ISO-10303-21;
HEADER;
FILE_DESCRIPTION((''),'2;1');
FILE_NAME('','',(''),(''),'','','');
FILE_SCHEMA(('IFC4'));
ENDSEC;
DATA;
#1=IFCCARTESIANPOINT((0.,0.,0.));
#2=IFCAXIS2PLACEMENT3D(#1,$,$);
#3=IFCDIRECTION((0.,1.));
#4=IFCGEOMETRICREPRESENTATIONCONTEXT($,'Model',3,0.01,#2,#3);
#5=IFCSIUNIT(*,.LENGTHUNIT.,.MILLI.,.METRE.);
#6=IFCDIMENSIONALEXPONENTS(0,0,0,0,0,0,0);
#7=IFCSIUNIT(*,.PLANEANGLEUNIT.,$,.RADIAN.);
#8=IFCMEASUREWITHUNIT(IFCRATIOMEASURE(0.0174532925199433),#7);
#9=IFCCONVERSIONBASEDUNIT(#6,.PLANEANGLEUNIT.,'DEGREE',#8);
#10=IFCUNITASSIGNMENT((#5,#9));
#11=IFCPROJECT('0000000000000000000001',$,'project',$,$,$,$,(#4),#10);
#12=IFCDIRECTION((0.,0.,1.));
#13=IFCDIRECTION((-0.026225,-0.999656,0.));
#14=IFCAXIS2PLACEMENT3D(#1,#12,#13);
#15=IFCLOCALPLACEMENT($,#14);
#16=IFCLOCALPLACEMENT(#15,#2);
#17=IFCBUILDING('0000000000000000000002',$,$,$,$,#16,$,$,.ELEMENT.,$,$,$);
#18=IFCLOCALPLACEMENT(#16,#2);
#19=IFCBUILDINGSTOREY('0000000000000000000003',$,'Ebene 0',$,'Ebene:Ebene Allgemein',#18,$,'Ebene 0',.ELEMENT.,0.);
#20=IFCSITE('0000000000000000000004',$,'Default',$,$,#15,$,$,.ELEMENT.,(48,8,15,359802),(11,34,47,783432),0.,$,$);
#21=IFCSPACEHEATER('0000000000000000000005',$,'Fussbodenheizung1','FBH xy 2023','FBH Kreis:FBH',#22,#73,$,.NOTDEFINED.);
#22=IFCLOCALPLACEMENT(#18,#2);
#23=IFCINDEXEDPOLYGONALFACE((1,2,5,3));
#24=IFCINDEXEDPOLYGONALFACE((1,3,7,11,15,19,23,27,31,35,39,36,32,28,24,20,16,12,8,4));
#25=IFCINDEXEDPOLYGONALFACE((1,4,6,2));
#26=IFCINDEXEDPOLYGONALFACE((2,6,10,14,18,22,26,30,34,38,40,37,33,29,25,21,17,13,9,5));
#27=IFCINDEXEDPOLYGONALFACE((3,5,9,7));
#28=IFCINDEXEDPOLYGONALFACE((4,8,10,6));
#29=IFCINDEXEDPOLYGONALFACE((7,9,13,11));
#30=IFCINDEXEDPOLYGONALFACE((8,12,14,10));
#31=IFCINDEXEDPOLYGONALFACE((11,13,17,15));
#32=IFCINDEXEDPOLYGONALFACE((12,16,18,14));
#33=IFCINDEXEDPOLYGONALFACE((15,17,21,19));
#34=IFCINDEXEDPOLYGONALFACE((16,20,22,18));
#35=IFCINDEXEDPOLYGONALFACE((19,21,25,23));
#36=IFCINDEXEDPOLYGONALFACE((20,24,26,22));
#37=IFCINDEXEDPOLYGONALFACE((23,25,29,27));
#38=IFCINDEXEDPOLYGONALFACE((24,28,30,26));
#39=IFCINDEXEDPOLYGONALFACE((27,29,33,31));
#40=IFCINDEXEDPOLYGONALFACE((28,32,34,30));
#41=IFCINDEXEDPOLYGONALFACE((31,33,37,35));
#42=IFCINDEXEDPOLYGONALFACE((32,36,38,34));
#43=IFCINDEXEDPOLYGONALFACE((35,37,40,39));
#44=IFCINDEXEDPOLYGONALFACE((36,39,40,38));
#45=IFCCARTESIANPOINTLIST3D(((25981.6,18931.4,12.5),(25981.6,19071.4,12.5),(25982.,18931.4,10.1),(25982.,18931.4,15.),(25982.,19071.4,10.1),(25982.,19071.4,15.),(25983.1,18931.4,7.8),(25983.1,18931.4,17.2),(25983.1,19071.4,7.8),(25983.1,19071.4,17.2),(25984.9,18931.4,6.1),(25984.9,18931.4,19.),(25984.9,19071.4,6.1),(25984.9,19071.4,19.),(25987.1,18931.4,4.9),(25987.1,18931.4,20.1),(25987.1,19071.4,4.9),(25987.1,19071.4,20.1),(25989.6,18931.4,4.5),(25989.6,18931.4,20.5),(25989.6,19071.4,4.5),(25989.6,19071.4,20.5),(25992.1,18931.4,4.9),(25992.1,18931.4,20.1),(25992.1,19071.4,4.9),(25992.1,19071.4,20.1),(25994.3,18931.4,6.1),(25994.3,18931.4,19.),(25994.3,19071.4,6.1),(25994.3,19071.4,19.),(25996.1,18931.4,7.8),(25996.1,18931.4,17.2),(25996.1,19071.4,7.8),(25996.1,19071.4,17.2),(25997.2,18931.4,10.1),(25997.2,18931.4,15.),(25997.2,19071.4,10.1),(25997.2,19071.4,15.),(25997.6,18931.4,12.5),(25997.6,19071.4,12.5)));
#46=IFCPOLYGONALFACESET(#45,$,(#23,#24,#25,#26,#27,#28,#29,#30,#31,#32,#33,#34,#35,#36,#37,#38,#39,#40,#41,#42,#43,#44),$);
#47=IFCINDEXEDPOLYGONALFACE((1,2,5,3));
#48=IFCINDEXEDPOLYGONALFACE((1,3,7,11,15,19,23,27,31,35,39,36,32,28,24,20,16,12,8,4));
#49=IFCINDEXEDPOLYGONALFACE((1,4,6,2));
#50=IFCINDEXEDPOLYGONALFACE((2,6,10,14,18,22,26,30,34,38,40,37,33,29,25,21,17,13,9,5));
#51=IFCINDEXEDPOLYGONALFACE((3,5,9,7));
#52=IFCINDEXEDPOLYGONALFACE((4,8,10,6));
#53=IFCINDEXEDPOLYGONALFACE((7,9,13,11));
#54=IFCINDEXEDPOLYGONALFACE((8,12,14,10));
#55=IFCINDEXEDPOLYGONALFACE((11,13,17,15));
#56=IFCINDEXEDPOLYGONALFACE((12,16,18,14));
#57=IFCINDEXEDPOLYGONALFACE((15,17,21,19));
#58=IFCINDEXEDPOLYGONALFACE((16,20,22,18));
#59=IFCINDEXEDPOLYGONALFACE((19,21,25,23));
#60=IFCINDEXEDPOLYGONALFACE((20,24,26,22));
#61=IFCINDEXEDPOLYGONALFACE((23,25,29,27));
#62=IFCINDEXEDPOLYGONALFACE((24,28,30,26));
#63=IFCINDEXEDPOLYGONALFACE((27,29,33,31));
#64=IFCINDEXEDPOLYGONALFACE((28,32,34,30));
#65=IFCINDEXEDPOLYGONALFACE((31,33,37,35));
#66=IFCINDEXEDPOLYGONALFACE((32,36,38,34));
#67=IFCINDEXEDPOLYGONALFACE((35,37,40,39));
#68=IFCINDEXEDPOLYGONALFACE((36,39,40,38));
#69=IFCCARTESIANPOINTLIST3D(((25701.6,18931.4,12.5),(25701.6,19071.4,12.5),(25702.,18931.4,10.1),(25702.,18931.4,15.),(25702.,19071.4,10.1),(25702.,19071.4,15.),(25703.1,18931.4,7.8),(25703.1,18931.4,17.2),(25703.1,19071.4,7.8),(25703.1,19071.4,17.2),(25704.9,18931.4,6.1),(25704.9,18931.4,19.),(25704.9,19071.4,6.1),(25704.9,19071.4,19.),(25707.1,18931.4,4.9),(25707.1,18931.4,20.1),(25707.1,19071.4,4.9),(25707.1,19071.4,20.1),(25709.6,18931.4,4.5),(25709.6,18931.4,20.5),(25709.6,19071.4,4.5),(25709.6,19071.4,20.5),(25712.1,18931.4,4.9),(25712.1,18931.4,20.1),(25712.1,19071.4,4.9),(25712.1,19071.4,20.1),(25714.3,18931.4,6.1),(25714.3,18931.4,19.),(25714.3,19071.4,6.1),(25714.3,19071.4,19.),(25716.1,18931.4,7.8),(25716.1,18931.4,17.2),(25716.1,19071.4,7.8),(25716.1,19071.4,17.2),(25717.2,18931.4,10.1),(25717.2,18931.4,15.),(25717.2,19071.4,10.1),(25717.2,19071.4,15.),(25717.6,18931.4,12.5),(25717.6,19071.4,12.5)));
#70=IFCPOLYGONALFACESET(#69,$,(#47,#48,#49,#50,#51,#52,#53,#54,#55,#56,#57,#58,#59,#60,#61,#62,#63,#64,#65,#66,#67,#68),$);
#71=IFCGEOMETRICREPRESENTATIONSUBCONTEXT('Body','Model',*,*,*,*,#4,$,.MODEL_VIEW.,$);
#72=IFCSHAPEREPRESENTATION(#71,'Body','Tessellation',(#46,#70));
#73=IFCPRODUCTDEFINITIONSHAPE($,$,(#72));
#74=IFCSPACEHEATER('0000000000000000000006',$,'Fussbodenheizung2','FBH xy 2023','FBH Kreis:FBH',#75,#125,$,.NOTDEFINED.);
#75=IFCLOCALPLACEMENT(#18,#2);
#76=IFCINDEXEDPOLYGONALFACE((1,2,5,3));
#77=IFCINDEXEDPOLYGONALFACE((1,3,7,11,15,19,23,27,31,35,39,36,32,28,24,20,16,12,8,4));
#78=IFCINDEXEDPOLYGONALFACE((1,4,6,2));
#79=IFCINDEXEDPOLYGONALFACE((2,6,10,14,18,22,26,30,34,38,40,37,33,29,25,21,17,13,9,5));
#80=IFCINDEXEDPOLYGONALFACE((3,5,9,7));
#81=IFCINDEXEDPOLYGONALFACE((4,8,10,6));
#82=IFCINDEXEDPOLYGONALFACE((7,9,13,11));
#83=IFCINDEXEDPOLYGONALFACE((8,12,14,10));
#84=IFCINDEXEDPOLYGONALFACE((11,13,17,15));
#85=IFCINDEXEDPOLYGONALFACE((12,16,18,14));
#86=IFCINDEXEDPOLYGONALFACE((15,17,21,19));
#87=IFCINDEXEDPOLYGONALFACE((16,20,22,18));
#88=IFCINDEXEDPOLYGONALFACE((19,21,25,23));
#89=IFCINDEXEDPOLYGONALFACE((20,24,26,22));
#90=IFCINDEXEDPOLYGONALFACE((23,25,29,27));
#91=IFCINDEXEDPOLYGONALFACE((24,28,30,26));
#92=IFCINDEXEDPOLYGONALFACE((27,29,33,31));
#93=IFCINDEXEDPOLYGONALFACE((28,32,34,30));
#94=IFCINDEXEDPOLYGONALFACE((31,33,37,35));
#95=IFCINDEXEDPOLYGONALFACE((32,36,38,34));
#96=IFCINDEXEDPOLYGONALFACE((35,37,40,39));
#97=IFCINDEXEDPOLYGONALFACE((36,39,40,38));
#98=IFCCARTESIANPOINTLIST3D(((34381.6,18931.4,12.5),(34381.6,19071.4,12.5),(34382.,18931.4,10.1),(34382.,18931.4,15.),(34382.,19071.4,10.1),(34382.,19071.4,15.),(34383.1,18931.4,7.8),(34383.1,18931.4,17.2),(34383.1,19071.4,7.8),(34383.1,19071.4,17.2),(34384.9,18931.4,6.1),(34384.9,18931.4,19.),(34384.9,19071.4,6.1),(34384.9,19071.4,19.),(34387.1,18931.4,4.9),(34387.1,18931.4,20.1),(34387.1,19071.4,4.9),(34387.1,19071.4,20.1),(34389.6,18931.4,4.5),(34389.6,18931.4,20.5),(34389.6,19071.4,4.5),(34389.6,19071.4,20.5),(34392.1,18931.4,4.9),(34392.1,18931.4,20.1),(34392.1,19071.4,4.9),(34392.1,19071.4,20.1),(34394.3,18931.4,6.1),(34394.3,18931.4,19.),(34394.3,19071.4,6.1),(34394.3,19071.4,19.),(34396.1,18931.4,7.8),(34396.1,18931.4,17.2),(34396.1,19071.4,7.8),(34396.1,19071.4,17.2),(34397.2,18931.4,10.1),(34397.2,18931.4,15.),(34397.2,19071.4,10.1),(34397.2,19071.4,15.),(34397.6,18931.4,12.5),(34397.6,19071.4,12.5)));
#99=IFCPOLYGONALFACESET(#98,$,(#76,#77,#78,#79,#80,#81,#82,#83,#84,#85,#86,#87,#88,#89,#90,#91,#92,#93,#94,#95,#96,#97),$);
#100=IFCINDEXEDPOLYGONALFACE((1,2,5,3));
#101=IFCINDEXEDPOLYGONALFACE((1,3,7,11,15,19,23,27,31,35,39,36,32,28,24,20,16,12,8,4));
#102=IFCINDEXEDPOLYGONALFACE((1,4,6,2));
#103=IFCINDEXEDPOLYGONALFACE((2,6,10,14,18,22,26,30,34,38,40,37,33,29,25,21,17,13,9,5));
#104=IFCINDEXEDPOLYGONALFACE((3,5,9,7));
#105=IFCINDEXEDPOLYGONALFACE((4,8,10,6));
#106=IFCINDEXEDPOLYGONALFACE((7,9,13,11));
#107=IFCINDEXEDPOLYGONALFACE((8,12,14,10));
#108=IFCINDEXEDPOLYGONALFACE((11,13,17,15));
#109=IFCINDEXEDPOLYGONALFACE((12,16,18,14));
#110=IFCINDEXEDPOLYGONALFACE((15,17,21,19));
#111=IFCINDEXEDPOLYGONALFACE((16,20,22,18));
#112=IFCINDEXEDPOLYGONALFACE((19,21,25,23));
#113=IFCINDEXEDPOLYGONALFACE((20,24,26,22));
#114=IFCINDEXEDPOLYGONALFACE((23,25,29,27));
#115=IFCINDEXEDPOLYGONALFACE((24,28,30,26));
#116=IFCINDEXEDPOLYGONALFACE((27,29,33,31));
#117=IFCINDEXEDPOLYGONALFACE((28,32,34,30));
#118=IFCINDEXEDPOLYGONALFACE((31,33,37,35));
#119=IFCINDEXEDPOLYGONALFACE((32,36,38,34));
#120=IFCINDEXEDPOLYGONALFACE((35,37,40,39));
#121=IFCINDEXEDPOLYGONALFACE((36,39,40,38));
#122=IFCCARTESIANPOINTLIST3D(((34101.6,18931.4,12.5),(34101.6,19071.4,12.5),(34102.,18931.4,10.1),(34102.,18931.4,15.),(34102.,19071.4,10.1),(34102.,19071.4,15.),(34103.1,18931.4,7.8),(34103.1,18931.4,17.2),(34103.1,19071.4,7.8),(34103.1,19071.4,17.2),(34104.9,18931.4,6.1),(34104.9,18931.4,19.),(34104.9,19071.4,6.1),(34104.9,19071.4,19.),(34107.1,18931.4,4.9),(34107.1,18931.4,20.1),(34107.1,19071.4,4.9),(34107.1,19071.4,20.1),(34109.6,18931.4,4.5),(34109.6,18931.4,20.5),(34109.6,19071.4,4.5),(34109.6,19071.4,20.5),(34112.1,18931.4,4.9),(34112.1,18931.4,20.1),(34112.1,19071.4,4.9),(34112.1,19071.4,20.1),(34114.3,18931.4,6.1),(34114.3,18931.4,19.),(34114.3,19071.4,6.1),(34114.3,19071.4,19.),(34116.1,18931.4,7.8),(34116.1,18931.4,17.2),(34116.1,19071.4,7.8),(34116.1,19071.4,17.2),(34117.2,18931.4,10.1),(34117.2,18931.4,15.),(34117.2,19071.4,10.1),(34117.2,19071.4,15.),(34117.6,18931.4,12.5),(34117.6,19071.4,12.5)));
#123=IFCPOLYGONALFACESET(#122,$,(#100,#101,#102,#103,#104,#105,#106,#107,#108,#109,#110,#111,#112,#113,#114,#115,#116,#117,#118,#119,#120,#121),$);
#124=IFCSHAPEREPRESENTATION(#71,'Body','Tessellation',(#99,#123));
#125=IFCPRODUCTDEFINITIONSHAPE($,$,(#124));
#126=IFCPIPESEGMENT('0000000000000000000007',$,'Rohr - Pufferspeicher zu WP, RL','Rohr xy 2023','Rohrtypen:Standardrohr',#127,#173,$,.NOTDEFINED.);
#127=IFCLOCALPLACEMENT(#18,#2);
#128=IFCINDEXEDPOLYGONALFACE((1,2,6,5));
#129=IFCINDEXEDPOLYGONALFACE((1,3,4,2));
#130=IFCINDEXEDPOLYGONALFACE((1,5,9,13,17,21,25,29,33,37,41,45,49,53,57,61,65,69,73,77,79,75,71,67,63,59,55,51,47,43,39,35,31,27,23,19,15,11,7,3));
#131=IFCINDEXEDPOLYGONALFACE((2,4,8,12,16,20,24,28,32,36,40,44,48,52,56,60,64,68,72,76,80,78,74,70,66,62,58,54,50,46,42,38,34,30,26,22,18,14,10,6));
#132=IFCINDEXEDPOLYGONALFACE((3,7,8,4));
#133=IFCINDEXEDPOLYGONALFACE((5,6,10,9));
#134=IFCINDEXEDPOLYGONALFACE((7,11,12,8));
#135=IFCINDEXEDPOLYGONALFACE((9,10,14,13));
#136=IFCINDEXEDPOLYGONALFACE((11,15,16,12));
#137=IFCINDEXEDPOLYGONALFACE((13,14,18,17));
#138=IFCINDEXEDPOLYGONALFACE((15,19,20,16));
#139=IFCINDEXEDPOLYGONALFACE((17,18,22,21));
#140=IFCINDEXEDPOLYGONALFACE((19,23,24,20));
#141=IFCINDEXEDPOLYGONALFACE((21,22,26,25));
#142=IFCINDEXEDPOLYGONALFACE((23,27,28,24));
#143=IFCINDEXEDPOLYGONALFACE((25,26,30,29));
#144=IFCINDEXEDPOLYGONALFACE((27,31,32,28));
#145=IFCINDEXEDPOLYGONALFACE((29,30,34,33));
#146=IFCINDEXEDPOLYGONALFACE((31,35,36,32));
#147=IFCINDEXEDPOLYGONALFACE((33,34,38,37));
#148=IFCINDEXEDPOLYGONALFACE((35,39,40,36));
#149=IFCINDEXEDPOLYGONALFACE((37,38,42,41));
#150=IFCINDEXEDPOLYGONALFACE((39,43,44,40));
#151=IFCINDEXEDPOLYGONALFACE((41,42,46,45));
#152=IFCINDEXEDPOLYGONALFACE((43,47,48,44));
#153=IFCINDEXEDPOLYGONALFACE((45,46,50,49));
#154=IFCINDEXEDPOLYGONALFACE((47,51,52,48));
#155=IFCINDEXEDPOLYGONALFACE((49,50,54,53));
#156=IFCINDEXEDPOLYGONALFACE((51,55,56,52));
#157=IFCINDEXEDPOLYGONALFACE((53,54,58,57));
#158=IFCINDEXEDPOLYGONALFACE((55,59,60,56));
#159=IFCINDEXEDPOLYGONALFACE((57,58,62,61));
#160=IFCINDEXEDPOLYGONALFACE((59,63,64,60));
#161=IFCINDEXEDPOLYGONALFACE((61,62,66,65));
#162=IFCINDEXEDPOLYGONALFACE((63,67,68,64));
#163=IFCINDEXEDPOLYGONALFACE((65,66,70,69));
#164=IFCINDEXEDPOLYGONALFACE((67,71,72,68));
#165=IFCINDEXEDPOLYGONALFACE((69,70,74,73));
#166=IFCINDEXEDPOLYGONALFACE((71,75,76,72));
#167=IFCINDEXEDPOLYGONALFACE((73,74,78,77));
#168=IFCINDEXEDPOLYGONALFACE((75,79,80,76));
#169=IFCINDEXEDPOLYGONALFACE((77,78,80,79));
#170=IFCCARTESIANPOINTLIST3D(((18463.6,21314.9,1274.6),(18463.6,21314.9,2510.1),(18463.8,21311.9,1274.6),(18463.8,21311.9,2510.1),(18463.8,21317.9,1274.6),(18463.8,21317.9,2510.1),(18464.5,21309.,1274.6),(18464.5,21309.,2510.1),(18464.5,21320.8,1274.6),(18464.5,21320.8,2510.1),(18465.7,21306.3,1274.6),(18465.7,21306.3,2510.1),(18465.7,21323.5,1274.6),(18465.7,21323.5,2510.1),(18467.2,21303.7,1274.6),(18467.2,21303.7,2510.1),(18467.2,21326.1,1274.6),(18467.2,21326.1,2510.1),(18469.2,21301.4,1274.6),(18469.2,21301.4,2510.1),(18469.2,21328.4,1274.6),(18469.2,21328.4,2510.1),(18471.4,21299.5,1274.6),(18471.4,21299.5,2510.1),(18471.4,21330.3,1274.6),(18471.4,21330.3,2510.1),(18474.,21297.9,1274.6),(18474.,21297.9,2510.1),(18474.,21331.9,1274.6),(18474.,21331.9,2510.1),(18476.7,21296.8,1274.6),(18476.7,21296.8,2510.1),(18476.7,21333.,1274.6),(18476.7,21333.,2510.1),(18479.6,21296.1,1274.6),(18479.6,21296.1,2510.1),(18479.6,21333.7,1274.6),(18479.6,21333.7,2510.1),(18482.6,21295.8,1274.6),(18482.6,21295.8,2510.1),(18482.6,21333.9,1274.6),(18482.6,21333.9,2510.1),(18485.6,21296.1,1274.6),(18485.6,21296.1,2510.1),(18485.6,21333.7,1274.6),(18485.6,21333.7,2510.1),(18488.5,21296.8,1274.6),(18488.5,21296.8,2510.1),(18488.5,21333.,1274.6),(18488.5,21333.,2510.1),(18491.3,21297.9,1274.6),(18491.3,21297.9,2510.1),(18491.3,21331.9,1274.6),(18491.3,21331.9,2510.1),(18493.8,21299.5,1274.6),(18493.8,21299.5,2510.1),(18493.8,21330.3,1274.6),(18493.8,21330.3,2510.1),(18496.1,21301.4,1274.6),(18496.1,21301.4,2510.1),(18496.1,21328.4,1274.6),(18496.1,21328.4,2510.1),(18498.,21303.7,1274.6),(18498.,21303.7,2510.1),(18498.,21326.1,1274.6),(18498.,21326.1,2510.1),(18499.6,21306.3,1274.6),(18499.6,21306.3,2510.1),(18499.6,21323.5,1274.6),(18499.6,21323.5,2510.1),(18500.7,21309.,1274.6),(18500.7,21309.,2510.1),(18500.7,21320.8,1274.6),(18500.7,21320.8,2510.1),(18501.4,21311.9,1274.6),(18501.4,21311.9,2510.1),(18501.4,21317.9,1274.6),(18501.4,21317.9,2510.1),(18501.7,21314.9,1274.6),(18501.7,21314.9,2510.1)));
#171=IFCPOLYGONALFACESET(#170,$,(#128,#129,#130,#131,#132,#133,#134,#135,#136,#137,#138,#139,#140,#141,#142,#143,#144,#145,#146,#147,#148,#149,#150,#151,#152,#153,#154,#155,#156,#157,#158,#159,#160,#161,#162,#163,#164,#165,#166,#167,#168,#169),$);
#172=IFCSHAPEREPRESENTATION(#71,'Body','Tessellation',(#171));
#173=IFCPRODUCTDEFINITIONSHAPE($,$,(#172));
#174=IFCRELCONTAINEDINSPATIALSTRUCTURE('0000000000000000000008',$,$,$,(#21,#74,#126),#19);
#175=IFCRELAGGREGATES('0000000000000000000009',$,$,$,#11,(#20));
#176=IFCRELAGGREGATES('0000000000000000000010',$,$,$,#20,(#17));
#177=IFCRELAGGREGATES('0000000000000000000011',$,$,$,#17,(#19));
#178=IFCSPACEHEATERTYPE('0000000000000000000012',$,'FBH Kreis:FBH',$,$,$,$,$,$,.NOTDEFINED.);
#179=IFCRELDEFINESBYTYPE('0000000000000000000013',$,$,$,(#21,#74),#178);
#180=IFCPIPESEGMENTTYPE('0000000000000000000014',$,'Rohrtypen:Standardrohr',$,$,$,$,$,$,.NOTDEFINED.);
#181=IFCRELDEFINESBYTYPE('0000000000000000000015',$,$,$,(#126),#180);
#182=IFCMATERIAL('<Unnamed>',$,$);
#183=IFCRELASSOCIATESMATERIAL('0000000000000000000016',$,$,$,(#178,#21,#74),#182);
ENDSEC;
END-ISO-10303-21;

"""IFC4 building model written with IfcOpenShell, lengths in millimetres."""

from ifc_helpers import new_model, entity, si_unit, converted_unit, direction, frame, origin, place, context, subcontext, project, spatial, indexed_curve, outline, extrude, source, transform, mapped, material, type_object, type_shapes, element, save


model = new_model("IFC4")

# Units and contexts
model_context = context("Model", 3, precision=0.01, world=origin(), true_north=direction((0.0, 1.0)))
body_context = subcontext(model_context, "Body", "Model", "MODEL_VIEW")
ifc_project = project(units=[si_unit("LENGTHUNIT", "METRE", prefix="MILLI"), converted_unit("PLANEANGLEUNIT", "DEGREE", entity("IfcRatioMeasure", 0.0174532925199433), si_unit("PLANEANGLEUNIT", "RADIAN"), dimensions=[0, 0, 0, 0, 0, 0, 0])], contexts=[model_context])

# Site, building, storey
site_placement = place(None, frame((0.0, 0.0, 0.0), z_axis=(0.0, 0.0, 1.0), x_axis=(-0.026225, -0.999656, 0.0)))
site = spatial("IfcSite", under=ifc_project, at=site_placement, Name="Default", CompositionType="ELEMENT", RefLatitude=(48, 8, 15, 359802), RefLongitude=(11, 34, 47, 783432), RefElevation=0.0)
building_placement = place(site_placement, origin())
building = spatial("IfcBuilding", under=site, at=building_placement, CompositionType="ELEMENT")
storey_placement = place(building_placement, origin())
storey = spatial("IfcBuildingStorey", under=building, at=storey_placement, Name="Ebene 0", ObjectType="Ebene:Ebene Allgemein", LongName="Ebene 0", CompositionType="ELEMENT", Elevation=0.0)

# Space heaters
ifc_material = material(Name="<Unnamed>")
space_heater_type = type_object("IfcSpaceHeaterType", Name="FBH Kreis:FBH", PredefinedType="NOTDEFINED", material=ifc_material)
shared_shape = source(origin(), body_context, "Body", "SweptSolid", [
    extrude(outline(indexed_curve([(8.0, 0.0), (7.6, 2.5), (6.5, 4.7), (4.7, 6.5), (2.5, 7.6), (0.0, 8.0), (-2.5, 7.6), (-4.7, 6.5), (-6.5, 4.7), (-7.6, 2.5), (-8.0, 0.0), (-7.6, -2.5), (-6.5, -4.7), (-4.7, -6.5), (-2.5, -7.6), (0.0, -8.0), (2.5, -7.6), (4.7, -6.5), (6.5, -4.7), (7.6, -2.5), (8.0, 0.0)], self_intersect=False)), frame((140.0, -1621.8, -83.0), z_axis=(0.0, 1.0, 0.0), x_axis=(1.0, 0.0, 0.0)), (0.0, 0.0, 1.0), 140.0),
    extrude(outline(indexed_curve([(8.0, 0.0), (7.6, 2.5), (6.5, 4.7), (4.7, 6.5), (2.5, 7.6), (0.0, 8.0), (-2.5, 7.6), (-4.7, 6.5), (-6.5, 4.7), (-7.6, 2.5), (-8.0, 0.0), (-7.6, -2.5), (-6.5, -4.7), (-4.7, -6.5), (-2.5, -7.6), (0.0, -8.0), (2.5, -7.6), (4.7, -6.5), (6.5, -4.7), (7.6, -2.5), (8.0, 0.0)], self_intersect=False)), frame((-140.0, -1621.8, -83.0), z_axis=(0.0, 1.0, 0.0), x_axis=(1.0, 0.0, 0.0)), (0.0, 0.0, 1.0), 140.0),
])
type_shapes(space_heater_type, [shared_shape])
for number, where, name in (
    (1, (25849.6, 20553.2, 95.5), "Fussbodenheizung1"),
    (2, (34249.6, 20553.2, 95.5), "Fussbodenheizung2"),
):
    element("IfcSpaceHeater", number, at=place(storey_placement, frame(where)), inside=storey, type_object=space_heater_type, material=ifc_material, Name=name, Description="FBH xy 2023", ObjectType="FBH Kreis:FBH", PredefinedType="NOTDEFINED", context=body_context, shape_type="MappedRepresentation", body=[
        mapped(shared_shape, transform((0.0, 0.0, 0.0), scale=1.0)),
    ])

# Pipe segment
pipe_segment_type = type_object("IfcPipeSegmentType", Name="Rohrtypen:Standardrohr", PredefinedType="NOTDEFINED")
pipe_segment_1_placement = place(storey_placement, origin())
element("IfcPipeSegment", 3, at=pipe_segment_1_placement, inside=storey, type_object=pipe_segment_type, Name="Rohr - Pufferspeicher zu WP, RL", Description="Rohr xy 2023", ObjectType="Rohrtypen:Standardrohr", PredefinedType="NOTDEFINED", context=body_context, shape_type="SweptSolid", body=[
    extrude(outline(indexed_curve([(19.1, 0.0), (18.8, 3.0), (18.1, 5.9), (17.0, 8.6), (15.4, 11.2), (13.5, 13.5), (11.2, 15.4), (8.6, 17.0), (5.9, 18.1), (3.0, 18.8), (0.0, 19.1), (-3.0, 18.8), (-5.9, 18.1), (-8.6, 17.0), (-11.2, 15.4), (-13.5, 13.5), (-15.4, 11.2), (-17.0, 8.6), (-18.1, 5.9), (-18.8, 3.0), (-19.1, 0.0), (-18.8, -3.0), (-18.1, -5.9), (-17.0, -8.6), (-15.4, -11.2), (-13.5, -13.5), (-11.2, -15.4), (-8.6, -17.0), (-5.9, -18.1), (-3.0, -18.8), (0.0, -19.1), (3.0, -18.8), (5.9, -18.1), (8.6, -17.0), (11.2, -15.4), (13.5, -13.5), (15.4, -11.2), (17.0, -8.6), (18.1, -5.9), (18.8, -3.0), (19.1, 0.0)], self_intersect=False)), frame((18482.6, 21314.9, 1274.6), z_axis=(0.0, 0.0, 1.0), x_axis=(-1.0, 0.0, 0.0)), (0.0, 0.0, 1.0), 1235.5),
])

save(model, "model.ifc")
